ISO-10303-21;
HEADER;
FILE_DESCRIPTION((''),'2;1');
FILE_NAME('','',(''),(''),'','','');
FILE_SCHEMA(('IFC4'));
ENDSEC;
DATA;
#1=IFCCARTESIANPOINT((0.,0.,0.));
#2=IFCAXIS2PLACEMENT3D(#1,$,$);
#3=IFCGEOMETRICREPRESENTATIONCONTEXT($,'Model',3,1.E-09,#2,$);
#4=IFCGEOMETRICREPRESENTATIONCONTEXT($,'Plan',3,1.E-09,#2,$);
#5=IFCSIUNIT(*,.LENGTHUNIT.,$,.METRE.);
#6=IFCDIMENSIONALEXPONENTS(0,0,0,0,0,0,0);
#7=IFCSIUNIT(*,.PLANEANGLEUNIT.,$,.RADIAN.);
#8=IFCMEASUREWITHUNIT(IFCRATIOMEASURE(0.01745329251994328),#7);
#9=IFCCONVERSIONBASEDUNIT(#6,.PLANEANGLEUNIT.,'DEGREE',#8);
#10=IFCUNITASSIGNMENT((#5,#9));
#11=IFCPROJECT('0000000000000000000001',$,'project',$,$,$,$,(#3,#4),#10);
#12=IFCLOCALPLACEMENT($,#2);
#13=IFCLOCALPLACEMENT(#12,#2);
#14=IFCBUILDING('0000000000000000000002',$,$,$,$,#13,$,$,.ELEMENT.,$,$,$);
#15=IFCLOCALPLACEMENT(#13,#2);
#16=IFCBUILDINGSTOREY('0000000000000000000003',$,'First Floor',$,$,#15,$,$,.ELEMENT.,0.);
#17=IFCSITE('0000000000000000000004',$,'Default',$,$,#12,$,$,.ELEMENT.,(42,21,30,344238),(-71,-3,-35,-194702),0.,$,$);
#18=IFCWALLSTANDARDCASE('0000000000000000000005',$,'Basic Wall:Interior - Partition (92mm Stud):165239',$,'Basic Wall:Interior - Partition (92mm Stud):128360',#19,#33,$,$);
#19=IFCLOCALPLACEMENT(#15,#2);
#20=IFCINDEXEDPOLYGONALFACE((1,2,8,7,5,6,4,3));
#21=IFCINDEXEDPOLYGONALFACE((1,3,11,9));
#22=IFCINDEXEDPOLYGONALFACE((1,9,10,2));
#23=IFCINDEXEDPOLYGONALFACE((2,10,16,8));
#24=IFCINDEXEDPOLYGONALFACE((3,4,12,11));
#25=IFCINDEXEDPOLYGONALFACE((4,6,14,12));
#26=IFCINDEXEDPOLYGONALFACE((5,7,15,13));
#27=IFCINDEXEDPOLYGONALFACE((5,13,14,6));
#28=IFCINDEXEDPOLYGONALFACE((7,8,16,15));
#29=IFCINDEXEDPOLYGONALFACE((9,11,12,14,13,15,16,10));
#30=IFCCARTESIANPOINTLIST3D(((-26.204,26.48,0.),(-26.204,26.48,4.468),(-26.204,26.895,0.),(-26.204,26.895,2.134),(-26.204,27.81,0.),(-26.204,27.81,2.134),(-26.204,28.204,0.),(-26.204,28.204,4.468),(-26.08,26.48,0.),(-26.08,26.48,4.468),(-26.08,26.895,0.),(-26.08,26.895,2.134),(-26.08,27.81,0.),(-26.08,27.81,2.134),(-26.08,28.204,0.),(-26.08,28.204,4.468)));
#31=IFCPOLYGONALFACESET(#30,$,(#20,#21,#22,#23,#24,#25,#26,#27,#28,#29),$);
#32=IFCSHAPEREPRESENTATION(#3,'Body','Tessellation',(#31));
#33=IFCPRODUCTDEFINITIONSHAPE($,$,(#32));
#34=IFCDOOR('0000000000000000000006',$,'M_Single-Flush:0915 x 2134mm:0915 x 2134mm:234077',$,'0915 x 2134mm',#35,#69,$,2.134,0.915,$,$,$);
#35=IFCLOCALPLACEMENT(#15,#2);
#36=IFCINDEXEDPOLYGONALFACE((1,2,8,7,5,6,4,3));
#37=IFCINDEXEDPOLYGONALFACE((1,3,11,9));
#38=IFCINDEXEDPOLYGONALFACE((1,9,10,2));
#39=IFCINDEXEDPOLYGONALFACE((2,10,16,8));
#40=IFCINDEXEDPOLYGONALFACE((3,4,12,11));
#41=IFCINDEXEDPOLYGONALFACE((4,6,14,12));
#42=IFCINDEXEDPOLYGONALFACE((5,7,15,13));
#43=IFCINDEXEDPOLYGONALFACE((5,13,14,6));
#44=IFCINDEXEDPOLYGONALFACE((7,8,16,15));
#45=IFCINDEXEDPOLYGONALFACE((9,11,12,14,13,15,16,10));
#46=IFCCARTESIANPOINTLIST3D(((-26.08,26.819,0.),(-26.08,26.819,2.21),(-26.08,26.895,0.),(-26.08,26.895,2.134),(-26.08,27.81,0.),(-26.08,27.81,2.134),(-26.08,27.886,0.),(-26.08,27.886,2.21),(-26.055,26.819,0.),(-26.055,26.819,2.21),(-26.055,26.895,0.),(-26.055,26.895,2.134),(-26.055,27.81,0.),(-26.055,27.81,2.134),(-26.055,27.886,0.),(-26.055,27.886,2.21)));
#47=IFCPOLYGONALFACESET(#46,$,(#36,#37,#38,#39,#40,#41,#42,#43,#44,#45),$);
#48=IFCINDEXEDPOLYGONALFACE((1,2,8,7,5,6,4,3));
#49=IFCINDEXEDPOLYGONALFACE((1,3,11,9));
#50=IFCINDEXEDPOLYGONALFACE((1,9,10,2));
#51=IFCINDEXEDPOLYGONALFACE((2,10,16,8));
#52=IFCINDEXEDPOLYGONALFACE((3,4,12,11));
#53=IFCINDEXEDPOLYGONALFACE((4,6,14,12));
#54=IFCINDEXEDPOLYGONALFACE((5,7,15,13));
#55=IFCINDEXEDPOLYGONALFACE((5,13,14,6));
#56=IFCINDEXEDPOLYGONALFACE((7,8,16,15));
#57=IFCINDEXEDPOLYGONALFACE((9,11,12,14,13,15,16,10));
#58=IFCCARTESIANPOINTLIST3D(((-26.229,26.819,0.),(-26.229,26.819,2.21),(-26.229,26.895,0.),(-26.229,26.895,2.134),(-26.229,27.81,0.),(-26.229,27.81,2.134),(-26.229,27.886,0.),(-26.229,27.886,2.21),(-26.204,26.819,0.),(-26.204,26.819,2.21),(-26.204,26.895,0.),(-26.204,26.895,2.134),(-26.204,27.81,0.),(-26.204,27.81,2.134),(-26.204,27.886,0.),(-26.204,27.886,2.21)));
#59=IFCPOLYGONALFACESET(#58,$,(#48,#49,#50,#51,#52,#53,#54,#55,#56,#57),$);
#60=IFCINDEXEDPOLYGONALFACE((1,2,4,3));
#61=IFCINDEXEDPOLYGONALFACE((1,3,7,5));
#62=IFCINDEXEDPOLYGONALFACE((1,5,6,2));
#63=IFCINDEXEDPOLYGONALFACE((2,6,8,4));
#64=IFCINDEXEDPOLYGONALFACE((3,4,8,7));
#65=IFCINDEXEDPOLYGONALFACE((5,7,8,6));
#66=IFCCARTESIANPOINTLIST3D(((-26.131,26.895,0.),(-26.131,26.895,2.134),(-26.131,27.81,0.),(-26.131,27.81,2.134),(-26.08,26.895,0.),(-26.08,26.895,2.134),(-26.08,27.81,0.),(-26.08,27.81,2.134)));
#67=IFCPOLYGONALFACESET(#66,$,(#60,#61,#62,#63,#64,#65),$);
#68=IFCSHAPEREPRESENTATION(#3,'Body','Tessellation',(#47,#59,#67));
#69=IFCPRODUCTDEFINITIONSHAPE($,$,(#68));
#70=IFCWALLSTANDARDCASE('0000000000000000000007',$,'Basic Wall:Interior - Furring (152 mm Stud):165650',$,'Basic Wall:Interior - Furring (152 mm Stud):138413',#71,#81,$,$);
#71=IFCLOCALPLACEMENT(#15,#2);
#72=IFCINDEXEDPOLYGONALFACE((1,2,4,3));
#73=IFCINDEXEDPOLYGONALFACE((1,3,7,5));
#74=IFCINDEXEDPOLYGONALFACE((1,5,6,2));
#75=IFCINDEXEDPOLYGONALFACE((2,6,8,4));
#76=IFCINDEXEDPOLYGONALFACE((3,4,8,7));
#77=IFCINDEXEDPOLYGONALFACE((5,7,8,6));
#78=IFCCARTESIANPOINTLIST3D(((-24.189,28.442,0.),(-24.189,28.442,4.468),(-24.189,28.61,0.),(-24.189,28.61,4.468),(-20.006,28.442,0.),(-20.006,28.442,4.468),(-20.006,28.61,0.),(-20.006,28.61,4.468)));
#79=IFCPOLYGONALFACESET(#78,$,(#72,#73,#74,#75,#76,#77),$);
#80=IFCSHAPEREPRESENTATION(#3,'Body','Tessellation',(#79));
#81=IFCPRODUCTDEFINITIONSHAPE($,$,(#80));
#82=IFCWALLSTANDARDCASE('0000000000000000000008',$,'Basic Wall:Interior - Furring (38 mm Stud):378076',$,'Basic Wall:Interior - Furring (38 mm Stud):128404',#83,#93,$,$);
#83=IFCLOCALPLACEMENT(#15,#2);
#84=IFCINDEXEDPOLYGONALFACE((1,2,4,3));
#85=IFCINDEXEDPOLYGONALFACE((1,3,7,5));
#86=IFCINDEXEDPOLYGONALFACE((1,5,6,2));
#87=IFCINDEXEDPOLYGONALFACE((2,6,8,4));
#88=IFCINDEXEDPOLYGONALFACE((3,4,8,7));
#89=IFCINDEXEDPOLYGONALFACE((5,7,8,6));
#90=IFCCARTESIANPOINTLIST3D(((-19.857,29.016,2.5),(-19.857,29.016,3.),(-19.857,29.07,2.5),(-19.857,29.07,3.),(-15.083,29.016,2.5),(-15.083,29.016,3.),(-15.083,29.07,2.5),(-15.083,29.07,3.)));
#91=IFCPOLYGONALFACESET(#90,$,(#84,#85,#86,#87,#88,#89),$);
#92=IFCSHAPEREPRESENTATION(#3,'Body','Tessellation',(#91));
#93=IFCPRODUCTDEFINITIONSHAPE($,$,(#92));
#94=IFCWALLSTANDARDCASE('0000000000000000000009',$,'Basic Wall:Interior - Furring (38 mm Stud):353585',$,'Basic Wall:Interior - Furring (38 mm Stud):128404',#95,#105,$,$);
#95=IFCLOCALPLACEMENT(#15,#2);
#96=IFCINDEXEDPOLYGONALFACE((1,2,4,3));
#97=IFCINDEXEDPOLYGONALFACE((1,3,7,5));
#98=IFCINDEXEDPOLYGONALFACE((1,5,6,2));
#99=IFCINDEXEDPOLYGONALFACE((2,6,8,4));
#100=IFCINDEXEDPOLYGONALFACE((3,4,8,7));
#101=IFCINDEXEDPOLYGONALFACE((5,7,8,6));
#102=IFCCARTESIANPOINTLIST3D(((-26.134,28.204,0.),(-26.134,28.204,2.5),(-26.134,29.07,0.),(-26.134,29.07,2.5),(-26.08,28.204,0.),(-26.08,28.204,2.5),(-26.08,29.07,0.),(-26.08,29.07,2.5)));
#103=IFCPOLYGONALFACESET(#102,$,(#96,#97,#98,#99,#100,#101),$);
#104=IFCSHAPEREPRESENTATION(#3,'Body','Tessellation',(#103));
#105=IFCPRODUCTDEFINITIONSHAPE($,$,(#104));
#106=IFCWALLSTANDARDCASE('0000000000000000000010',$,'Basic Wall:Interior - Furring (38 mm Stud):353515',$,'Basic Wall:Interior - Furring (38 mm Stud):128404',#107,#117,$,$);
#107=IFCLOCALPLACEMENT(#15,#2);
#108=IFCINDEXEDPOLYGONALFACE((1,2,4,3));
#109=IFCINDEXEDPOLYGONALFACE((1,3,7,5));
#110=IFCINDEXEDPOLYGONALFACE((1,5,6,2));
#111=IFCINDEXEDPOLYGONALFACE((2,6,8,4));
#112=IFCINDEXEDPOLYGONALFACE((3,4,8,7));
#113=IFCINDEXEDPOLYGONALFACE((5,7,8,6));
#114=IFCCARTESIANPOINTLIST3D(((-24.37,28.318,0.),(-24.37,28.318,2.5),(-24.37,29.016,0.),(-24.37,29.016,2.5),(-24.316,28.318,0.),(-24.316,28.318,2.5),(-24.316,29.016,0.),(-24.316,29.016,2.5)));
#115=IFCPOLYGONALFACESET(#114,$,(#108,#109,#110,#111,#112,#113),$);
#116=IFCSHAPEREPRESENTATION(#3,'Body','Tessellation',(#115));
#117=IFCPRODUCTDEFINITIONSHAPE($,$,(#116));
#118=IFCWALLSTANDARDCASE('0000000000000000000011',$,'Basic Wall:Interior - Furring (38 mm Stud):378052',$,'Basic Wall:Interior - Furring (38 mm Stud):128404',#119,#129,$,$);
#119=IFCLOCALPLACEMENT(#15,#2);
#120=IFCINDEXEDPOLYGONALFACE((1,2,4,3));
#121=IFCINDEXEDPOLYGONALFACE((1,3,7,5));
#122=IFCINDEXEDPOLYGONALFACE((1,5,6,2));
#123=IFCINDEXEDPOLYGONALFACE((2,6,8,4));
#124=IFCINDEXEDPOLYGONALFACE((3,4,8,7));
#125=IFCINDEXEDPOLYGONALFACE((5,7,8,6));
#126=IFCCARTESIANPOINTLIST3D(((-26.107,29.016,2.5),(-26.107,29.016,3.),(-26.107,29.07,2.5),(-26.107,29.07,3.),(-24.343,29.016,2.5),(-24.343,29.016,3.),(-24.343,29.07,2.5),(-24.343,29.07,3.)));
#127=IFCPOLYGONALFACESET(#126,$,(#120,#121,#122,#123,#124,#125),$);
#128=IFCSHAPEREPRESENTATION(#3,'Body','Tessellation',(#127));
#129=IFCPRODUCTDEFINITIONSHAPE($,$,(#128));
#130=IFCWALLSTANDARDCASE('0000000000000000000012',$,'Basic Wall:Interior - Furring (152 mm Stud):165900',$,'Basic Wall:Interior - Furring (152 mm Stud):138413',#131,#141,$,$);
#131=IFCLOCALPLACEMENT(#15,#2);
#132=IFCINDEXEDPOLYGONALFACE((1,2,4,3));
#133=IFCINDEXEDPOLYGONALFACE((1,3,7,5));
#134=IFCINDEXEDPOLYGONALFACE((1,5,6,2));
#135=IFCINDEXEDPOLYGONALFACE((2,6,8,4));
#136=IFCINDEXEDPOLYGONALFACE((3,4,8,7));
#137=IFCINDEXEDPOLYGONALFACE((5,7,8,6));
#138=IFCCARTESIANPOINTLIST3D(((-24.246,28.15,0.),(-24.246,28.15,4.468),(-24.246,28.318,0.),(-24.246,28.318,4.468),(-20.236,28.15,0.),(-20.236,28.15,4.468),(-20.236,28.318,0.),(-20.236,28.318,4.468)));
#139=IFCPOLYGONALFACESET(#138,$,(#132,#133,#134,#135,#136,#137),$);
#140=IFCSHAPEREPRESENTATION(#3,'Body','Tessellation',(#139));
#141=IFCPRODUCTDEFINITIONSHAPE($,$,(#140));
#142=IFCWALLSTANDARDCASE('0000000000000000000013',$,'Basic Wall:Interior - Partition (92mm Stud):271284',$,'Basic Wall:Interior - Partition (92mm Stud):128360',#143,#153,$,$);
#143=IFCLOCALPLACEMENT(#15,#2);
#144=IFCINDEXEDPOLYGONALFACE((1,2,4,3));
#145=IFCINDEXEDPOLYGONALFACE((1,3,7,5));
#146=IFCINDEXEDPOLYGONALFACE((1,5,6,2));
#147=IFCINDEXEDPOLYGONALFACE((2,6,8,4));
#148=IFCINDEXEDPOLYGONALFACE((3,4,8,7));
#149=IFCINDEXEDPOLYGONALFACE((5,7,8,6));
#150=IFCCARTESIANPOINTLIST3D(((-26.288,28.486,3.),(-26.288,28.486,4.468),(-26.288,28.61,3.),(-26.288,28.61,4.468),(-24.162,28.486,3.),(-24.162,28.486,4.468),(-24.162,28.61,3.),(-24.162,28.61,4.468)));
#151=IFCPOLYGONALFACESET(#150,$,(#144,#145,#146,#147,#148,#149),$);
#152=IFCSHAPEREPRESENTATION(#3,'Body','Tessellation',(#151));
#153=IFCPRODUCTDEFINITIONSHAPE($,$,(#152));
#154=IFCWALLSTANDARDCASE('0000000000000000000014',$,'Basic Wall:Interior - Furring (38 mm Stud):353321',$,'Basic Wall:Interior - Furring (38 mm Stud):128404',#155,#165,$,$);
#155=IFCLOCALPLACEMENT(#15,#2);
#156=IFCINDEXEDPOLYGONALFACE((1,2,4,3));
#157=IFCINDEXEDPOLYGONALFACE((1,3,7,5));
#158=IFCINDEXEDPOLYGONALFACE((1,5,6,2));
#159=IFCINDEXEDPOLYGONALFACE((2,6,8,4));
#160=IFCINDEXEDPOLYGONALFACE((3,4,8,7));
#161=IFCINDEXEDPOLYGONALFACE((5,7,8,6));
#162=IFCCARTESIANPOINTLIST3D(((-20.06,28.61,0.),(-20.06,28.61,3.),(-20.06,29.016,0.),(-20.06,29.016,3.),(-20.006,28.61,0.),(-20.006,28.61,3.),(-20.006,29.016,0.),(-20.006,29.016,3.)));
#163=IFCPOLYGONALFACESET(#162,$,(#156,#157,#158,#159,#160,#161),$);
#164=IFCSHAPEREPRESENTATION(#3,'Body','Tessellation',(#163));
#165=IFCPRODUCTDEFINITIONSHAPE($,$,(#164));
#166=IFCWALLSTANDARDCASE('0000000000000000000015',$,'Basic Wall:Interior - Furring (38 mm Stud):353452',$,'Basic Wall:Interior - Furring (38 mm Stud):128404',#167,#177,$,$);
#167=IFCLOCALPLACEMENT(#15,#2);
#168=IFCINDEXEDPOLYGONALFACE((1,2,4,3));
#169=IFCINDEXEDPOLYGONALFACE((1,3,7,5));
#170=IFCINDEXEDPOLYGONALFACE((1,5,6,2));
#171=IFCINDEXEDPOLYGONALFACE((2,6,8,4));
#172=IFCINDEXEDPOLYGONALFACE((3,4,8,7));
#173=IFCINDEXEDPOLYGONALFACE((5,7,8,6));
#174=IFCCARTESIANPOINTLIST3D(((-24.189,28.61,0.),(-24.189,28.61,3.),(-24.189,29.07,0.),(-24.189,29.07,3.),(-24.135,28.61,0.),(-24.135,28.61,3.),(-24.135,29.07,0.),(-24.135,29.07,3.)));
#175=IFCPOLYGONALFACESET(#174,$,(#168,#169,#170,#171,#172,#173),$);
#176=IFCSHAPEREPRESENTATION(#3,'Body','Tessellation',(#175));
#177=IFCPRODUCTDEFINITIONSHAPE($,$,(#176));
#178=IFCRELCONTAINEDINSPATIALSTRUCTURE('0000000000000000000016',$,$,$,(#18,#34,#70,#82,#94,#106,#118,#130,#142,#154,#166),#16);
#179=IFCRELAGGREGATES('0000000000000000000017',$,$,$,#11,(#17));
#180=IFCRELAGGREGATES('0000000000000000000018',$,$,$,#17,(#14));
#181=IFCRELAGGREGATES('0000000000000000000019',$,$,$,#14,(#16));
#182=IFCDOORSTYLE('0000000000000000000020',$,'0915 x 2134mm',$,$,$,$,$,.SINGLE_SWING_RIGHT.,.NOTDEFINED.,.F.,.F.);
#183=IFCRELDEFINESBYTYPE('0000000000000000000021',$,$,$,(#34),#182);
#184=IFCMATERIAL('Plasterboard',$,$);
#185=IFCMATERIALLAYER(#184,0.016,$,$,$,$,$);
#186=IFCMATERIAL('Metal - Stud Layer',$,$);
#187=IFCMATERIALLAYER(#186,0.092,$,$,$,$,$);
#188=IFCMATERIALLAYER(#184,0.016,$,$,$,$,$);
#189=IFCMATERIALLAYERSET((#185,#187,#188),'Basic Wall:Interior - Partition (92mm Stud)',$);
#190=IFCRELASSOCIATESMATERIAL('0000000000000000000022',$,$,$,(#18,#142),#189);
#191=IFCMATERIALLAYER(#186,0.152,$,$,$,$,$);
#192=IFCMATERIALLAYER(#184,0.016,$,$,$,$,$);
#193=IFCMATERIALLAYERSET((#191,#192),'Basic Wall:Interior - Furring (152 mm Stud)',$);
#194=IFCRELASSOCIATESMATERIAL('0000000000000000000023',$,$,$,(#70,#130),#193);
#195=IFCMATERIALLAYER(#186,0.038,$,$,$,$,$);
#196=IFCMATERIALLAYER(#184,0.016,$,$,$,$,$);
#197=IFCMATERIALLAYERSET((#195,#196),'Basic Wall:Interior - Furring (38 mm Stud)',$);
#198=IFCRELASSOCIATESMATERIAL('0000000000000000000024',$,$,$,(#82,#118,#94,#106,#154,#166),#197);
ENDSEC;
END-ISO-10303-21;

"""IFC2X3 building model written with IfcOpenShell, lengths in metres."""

from ifc_helpers import new_model, entity, si_unit, converted_unit, frame, frame_2d, origin, origin_2d_with_axis, place, context, project, spatial, polyline, rectangle, outline, extrude, source, transform, mapped, material, layer, layer_set, layer_usage, type_object, type_shapes, element, fill, save


model = new_model("IFC2X3")

# Units and contexts
model_context = context("Model", 3, precision=1e-09, world=origin())
plan_context = context("Plan", 3, precision=1e-09, world=origin())
ifc_project = project(units=[si_unit("LENGTHUNIT", "METRE"), converted_unit("PLANEANGLEUNIT", "DEGREE", entity("IfcRatioMeasure", 0.01745329251994328), si_unit("PLANEANGLEUNIT", "RADIAN"), dimensions=[0, 0, 0, 0, 0, 0, 0])], contexts=[model_context, plan_context])

# Site, building, storey
site_placement = place(None, origin())
site = spatial("IfcSite", under=ifc_project, at=site_placement, Name="Default", CompositionType="ELEMENT", RefLatitude=(42, 21, 30, 344238), RefLongitude=(-71, -3, -35, -194702), RefElevation=0.0)
building_placement = place(site_placement, origin())
building = spatial("IfcBuilding", under=site, at=building_placement, CompositionType="ELEMENT")
storey_placement = place(building_placement, origin())
storey = spatial("IfcBuildingStorey", under=building, at=storey_placement, Name="First Floor", CompositionType="ELEMENT", Elevation=0.0)

# Shared definitions
ifc_material_1 = material(Name="Metal - Stud Layer")
ifc_layer_1 = layer(ifc_material_1, 0.152)
ifc_material_2 = material(Name="Plasterboard")
ifc_layer_2 = layer(ifc_material_2, 0.016)
ifc_layer_set_1 = layer_set([ifc_layer_1, ifc_layer_2], Name="Basic Wall:Interior - Furring (152 mm Stud)")
ifc_layer_usage_1 = layer_usage(ifc_layer_set_1, "AXIS2", "POSITIVE", -0.084)

# Wall, opening, door
ifc_layer_3 = layer(ifc_material_2, 0.016)
ifc_layer_4 = layer(ifc_material_1, 0.092)
ifc_layer_5 = layer(ifc_material_2, 0.016)
ifc_layer_set_2 = layer_set([ifc_layer_3, ifc_layer_4, ifc_layer_5], Name="Basic Wall:Interior - Partition (92mm Stud)")
ifc_layer_usage_2 = layer_usage(ifc_layer_set_2, "AXIS2", "NEGATIVE", 0.062)
wall_1_placement = place(storey_placement, frame((-26.142, 28.204, 0.0), z_axis=(0.0, 0.0, 1.0), x_axis=(0.0, -1.0, 0.0)))
wall_1 = element("IfcWallStandardCase", 1, at=wall_1_placement, inside=storey, material=ifc_layer_usage_2, Name="Basic Wall:Interior - Partition (92mm Stud):165239", ObjectType="Basic Wall:Interior - Partition (92mm Stud):128360", context=model_context, shape_type="SweptSolid", body=[
    extrude(rectangle(XDim=1.724, YDim=0.124, at=frame_2d((0.862, 0.0), x_axis=(-1.0, 0.0))), origin(), (0.0, 0.0, 1.0), 4.468),
])
opening_1_placement = place(wall_1_placement, frame((0.394, -0.062, 0.0)))
opening_1 = element("IfcOpeningElement", 2, at=opening_1_placement, cuts=wall_1, ObjectType="Opening", context=model_context, shape_type="SweptSolid", body=[
    extrude(rectangle(XDim=0.915, YDim=2.134, at=frame_2d((1.067, 0.4575), x_axis=(0.0, 1.0))), frame((0.0, 0.0, 0.0), z_axis=(0.0, 1.0, 0.0), x_axis=(0.0, 0.0, 1.0)), (0.0, 0.0, 1.0), 0.124),
])
door_style = type_object("IfcDoorStyle", Name="0915 x 2134mm", ConstructionType="NOTDEFINED", OperationType="SINGLE_SWING_RIGHT", ParameterTakesPrecedence=False, Sizeable=False)
shared_shape = source(origin(), model_context, "Body", "SweptSolid", [
    extrude(outline(polyline([(-0.5335, -1.124), (0.5335, -1.124), (0.5335, 1.086), (0.4575, 1.086), (0.4575, -1.048), (-0.4575, -1.048), (-0.4575, 1.086), (-0.5335, 1.086), (-0.5335, -1.124)])), frame((0.4575, 0.124, 1.086), z_axis=(0.0, 1.0, 0.0), x_axis=(1.0, 0.0, 0.0)), (0.0, 0.0, 1.0), 0.025),
    extrude(outline(polyline([(-1.124, -0.5335), (1.086, -0.5335), (1.086, -0.4575), (-1.048, -0.4575), (-1.048, 0.4575), (1.086, 0.4575), (1.086, 0.5335), (-1.124, 0.5335), (-1.124, -0.5335)])), frame((0.4575, -0.025, 1.086), z_axis=(0.0, 1.0, 0.0), x_axis=(0.0, 0.0, -1.0)), (0.0, 0.0, 1.0), 0.025),
    extrude(rectangle(XDim=0.051, YDim=0.915, at=origin_2d_with_axis()), frame((0.4575, 0.0985, 0.0), z_axis=(0.0, 0.0, 1.0), x_axis=(0.0, 1.0, 0.0)), (0.0, 0.0, 1.0), 2.134),
])
type_shapes(door_style, [shared_shape])
door_placement = place(opening_1_placement, origin())
door = element("IfcDoor", 3, at=door_placement, inside=storey, type_object=door_style, Name="M_Single-Flush:0915 x 2134mm:0915 x 2134mm:234077", ObjectType="0915 x 2134mm", OverallHeight=2.134, OverallWidth=0.915, context=model_context, shape_type="MappedRepresentation", body=[
    mapped(shared_shape, transform((0.0, 0.0, 0.0), scale=1.0)),
])
fill(opening_1, door)

# Walls
wall_2_placement = place(storey_placement, frame((-24.189, 28.526, 0.0)))
element("IfcWallStandardCase", 4, at=wall_2_placement, inside=storey, material=ifc_layer_usage_1, Name="Basic Wall:Interior - Furring (152 mm Stud):165650", ObjectType="Basic Wall:Interior - Furring (152 mm Stud):138413", context=model_context, shape_type="SweptSolid", body=[
    extrude(rectangle(XDim=4.183, YDim=0.168, at=frame_2d((2.0915, 0.0), x_axis=(-1.0, 0.0))), origin(), (0.0, 0.0, 1.0), 4.468),
])
ifc_layer_6 = layer(ifc_material_1, 0.038)
ifc_layer_7 = layer(ifc_material_2, 0.016)
ifc_layer_set_3 = layer_set([ifc_layer_6, ifc_layer_7], Name="Basic Wall:Interior - Furring (38 mm Stud)")
ifc_layer_usage_3 = layer_usage(ifc_layer_set_3, "AXIS2", "POSITIVE", -0.027)
wall_3_placement = place(storey_placement, frame((-19.857, 29.043, 2.5)))
element("IfcWallStandardCase", 5, at=wall_3_placement, inside=storey, material=ifc_layer_usage_3, Name="Basic Wall:Interior - Furring (38 mm Stud):378076", ObjectType="Basic Wall:Interior - Furring (38 mm Stud):128404", context=model_context, shape_type="SweptSolid", body=[
    extrude(rectangle(XDim=4.774, YDim=0.054, at=frame_2d((2.387, 0.0), x_axis=(-1.0, 0.0))), origin(), (0.0, 0.0, 1.0), 0.5),
])
ifc_layer_usage_4 = layer_usage(ifc_layer_set_3, "AXIS2", "NEGATIVE", 0.027)
wall_4_placement = place(storey_placement, frame((-26.107, 28.204, 0.0), z_axis=(0.0, 0.0, 1.0), x_axis=(0.0, 1.0, 0.0)))
element("IfcWallStandardCase", 6, at=wall_4_placement, inside=storey, material=ifc_layer_usage_4, Name="Basic Wall:Interior - Furring (38 mm Stud):353585", ObjectType="Basic Wall:Interior - Furring (38 mm Stud):128404", context=model_context, shape_type="SweptSolid", body=[
    extrude(rectangle(XDim=0.866, YDim=0.054, at=frame_2d((0.433, 0.0), x_axis=(-1.0, 0.0))), origin(), (0.0, 0.0, 1.0), 2.5),
])
wall_5_placement = place(storey_placement, frame((-24.343, 29.016, 0.0), z_axis=(0.0, 0.0, 1.0), x_axis=(0.0, -1.0, 0.0)))
element("IfcWallStandardCase", 7, at=wall_5_placement, inside=storey, material=ifc_layer_usage_4, Name="Basic Wall:Interior - Furring (38 mm Stud):353515", ObjectType="Basic Wall:Interior - Furring (38 mm Stud):128404", context=model_context, shape_type="SweptSolid", body=[
    extrude(rectangle(XDim=0.698, YDim=0.054, at=frame_2d((0.349, 0.0), x_axis=(-1.0, 0.0))), origin(), (0.0, 0.0, 1.0), 2.5),
])
wall_6_placement = place(storey_placement, frame((-26.107, 29.043, 2.5)))
element("IfcWallStandardCase", 8, at=wall_6_placement, inside=storey, material=ifc_layer_usage_3, Name="Basic Wall:Interior - Furring (38 mm Stud):378052", ObjectType="Basic Wall:Interior - Furring (38 mm Stud):128404", context=model_context, shape_type="SweptSolid", body=[
    extrude(rectangle(XDim=1.764, YDim=0.054, at=frame_2d((0.882, 0.0), x_axis=(-1.0, 0.0))), origin(), (0.0, 0.0, 1.0), 0.5),
])
wall_7_placement = place(storey_placement, frame((-20.236, 28.234, 0.0), z_axis=(0.0, 0.0, 1.0), x_axis=(-1.0, 0.0, 0.0)))
element("IfcWallStandardCase", 9, at=wall_7_placement, inside=storey, material=ifc_layer_usage_1, Name="Basic Wall:Interior - Furring (152 mm Stud):165900", ObjectType="Basic Wall:Interior - Furring (152 mm Stud):138413", context=model_context, shape_type="SweptSolid", body=[
    extrude(rectangle(XDim=4.01, YDim=0.168, at=frame_2d((2.005, 0.0), x_axis=(-1.0, 0.0))), origin(), (0.0, 0.0, 1.0), 4.468),
])
wall_8_placement = place(storey_placement, frame((-24.162, 28.548, 3.0), z_axis=(0.0, 0.0, 1.0), x_axis=(-1.0, 0.0, 0.0)))
element("IfcWallStandardCase", 10, at=wall_8_placement, inside=storey, material=ifc_layer_usage_2, Name="Basic Wall:Interior - Partition (92mm Stud):271284", ObjectType="Basic Wall:Interior - Partition (92mm Stud):128360", context=model_context, shape_type="SweptSolid", body=[
    extrude(rectangle(XDim=2.126, YDim=0.124, at=frame_2d((1.063, 0.0), x_axis=(-1.0, 0.0))), origin(), (0.0, 0.0, 1.0), 1.468),
])
wall_9_placement = place(storey_placement, frame((-20.033, 29.016, 0.0), z_axis=(0.0, 0.0, 1.0), x_axis=(0.0, -1.0, 0.0)))
element("IfcWallStandardCase", 11, at=wall_9_placement, inside=storey, material=ifc_layer_usage_4, Name="Basic Wall:Interior - Furring (38 mm Stud):353321", ObjectType="Basic Wall:Interior - Furring (38 mm Stud):128404", context=model_context, shape_type="SweptSolid", body=[
    extrude(rectangle(XDim=0.406, YDim=0.054, at=frame_2d((0.203, 0.0), x_axis=(-1.0, 0.0))), origin(), (0.0, 0.0, 1.0), 3.0),
])
wall_10_placement = place(storey_placement, frame((-24.162, 28.61, 0.0), z_axis=(0.0, 0.0, 1.0), x_axis=(0.0, 1.0, 0.0)))
element("IfcWallStandardCase", 12, at=wall_10_placement, inside=storey, material=ifc_layer_usage_4, Name="Basic Wall:Interior - Furring (38 mm Stud):353452", ObjectType="Basic Wall:Interior - Furring (38 mm Stud):128404", context=model_context, shape_type="SweptSolid", body=[
    extrude(rectangle(XDim=0.46, YDim=0.054, at=frame_2d((0.23, 0.0), x_axis=(-1.0, 0.0))), origin(), (0.0, 0.0, 1.0), 3.0),
])

save(model, "model.ifc")
